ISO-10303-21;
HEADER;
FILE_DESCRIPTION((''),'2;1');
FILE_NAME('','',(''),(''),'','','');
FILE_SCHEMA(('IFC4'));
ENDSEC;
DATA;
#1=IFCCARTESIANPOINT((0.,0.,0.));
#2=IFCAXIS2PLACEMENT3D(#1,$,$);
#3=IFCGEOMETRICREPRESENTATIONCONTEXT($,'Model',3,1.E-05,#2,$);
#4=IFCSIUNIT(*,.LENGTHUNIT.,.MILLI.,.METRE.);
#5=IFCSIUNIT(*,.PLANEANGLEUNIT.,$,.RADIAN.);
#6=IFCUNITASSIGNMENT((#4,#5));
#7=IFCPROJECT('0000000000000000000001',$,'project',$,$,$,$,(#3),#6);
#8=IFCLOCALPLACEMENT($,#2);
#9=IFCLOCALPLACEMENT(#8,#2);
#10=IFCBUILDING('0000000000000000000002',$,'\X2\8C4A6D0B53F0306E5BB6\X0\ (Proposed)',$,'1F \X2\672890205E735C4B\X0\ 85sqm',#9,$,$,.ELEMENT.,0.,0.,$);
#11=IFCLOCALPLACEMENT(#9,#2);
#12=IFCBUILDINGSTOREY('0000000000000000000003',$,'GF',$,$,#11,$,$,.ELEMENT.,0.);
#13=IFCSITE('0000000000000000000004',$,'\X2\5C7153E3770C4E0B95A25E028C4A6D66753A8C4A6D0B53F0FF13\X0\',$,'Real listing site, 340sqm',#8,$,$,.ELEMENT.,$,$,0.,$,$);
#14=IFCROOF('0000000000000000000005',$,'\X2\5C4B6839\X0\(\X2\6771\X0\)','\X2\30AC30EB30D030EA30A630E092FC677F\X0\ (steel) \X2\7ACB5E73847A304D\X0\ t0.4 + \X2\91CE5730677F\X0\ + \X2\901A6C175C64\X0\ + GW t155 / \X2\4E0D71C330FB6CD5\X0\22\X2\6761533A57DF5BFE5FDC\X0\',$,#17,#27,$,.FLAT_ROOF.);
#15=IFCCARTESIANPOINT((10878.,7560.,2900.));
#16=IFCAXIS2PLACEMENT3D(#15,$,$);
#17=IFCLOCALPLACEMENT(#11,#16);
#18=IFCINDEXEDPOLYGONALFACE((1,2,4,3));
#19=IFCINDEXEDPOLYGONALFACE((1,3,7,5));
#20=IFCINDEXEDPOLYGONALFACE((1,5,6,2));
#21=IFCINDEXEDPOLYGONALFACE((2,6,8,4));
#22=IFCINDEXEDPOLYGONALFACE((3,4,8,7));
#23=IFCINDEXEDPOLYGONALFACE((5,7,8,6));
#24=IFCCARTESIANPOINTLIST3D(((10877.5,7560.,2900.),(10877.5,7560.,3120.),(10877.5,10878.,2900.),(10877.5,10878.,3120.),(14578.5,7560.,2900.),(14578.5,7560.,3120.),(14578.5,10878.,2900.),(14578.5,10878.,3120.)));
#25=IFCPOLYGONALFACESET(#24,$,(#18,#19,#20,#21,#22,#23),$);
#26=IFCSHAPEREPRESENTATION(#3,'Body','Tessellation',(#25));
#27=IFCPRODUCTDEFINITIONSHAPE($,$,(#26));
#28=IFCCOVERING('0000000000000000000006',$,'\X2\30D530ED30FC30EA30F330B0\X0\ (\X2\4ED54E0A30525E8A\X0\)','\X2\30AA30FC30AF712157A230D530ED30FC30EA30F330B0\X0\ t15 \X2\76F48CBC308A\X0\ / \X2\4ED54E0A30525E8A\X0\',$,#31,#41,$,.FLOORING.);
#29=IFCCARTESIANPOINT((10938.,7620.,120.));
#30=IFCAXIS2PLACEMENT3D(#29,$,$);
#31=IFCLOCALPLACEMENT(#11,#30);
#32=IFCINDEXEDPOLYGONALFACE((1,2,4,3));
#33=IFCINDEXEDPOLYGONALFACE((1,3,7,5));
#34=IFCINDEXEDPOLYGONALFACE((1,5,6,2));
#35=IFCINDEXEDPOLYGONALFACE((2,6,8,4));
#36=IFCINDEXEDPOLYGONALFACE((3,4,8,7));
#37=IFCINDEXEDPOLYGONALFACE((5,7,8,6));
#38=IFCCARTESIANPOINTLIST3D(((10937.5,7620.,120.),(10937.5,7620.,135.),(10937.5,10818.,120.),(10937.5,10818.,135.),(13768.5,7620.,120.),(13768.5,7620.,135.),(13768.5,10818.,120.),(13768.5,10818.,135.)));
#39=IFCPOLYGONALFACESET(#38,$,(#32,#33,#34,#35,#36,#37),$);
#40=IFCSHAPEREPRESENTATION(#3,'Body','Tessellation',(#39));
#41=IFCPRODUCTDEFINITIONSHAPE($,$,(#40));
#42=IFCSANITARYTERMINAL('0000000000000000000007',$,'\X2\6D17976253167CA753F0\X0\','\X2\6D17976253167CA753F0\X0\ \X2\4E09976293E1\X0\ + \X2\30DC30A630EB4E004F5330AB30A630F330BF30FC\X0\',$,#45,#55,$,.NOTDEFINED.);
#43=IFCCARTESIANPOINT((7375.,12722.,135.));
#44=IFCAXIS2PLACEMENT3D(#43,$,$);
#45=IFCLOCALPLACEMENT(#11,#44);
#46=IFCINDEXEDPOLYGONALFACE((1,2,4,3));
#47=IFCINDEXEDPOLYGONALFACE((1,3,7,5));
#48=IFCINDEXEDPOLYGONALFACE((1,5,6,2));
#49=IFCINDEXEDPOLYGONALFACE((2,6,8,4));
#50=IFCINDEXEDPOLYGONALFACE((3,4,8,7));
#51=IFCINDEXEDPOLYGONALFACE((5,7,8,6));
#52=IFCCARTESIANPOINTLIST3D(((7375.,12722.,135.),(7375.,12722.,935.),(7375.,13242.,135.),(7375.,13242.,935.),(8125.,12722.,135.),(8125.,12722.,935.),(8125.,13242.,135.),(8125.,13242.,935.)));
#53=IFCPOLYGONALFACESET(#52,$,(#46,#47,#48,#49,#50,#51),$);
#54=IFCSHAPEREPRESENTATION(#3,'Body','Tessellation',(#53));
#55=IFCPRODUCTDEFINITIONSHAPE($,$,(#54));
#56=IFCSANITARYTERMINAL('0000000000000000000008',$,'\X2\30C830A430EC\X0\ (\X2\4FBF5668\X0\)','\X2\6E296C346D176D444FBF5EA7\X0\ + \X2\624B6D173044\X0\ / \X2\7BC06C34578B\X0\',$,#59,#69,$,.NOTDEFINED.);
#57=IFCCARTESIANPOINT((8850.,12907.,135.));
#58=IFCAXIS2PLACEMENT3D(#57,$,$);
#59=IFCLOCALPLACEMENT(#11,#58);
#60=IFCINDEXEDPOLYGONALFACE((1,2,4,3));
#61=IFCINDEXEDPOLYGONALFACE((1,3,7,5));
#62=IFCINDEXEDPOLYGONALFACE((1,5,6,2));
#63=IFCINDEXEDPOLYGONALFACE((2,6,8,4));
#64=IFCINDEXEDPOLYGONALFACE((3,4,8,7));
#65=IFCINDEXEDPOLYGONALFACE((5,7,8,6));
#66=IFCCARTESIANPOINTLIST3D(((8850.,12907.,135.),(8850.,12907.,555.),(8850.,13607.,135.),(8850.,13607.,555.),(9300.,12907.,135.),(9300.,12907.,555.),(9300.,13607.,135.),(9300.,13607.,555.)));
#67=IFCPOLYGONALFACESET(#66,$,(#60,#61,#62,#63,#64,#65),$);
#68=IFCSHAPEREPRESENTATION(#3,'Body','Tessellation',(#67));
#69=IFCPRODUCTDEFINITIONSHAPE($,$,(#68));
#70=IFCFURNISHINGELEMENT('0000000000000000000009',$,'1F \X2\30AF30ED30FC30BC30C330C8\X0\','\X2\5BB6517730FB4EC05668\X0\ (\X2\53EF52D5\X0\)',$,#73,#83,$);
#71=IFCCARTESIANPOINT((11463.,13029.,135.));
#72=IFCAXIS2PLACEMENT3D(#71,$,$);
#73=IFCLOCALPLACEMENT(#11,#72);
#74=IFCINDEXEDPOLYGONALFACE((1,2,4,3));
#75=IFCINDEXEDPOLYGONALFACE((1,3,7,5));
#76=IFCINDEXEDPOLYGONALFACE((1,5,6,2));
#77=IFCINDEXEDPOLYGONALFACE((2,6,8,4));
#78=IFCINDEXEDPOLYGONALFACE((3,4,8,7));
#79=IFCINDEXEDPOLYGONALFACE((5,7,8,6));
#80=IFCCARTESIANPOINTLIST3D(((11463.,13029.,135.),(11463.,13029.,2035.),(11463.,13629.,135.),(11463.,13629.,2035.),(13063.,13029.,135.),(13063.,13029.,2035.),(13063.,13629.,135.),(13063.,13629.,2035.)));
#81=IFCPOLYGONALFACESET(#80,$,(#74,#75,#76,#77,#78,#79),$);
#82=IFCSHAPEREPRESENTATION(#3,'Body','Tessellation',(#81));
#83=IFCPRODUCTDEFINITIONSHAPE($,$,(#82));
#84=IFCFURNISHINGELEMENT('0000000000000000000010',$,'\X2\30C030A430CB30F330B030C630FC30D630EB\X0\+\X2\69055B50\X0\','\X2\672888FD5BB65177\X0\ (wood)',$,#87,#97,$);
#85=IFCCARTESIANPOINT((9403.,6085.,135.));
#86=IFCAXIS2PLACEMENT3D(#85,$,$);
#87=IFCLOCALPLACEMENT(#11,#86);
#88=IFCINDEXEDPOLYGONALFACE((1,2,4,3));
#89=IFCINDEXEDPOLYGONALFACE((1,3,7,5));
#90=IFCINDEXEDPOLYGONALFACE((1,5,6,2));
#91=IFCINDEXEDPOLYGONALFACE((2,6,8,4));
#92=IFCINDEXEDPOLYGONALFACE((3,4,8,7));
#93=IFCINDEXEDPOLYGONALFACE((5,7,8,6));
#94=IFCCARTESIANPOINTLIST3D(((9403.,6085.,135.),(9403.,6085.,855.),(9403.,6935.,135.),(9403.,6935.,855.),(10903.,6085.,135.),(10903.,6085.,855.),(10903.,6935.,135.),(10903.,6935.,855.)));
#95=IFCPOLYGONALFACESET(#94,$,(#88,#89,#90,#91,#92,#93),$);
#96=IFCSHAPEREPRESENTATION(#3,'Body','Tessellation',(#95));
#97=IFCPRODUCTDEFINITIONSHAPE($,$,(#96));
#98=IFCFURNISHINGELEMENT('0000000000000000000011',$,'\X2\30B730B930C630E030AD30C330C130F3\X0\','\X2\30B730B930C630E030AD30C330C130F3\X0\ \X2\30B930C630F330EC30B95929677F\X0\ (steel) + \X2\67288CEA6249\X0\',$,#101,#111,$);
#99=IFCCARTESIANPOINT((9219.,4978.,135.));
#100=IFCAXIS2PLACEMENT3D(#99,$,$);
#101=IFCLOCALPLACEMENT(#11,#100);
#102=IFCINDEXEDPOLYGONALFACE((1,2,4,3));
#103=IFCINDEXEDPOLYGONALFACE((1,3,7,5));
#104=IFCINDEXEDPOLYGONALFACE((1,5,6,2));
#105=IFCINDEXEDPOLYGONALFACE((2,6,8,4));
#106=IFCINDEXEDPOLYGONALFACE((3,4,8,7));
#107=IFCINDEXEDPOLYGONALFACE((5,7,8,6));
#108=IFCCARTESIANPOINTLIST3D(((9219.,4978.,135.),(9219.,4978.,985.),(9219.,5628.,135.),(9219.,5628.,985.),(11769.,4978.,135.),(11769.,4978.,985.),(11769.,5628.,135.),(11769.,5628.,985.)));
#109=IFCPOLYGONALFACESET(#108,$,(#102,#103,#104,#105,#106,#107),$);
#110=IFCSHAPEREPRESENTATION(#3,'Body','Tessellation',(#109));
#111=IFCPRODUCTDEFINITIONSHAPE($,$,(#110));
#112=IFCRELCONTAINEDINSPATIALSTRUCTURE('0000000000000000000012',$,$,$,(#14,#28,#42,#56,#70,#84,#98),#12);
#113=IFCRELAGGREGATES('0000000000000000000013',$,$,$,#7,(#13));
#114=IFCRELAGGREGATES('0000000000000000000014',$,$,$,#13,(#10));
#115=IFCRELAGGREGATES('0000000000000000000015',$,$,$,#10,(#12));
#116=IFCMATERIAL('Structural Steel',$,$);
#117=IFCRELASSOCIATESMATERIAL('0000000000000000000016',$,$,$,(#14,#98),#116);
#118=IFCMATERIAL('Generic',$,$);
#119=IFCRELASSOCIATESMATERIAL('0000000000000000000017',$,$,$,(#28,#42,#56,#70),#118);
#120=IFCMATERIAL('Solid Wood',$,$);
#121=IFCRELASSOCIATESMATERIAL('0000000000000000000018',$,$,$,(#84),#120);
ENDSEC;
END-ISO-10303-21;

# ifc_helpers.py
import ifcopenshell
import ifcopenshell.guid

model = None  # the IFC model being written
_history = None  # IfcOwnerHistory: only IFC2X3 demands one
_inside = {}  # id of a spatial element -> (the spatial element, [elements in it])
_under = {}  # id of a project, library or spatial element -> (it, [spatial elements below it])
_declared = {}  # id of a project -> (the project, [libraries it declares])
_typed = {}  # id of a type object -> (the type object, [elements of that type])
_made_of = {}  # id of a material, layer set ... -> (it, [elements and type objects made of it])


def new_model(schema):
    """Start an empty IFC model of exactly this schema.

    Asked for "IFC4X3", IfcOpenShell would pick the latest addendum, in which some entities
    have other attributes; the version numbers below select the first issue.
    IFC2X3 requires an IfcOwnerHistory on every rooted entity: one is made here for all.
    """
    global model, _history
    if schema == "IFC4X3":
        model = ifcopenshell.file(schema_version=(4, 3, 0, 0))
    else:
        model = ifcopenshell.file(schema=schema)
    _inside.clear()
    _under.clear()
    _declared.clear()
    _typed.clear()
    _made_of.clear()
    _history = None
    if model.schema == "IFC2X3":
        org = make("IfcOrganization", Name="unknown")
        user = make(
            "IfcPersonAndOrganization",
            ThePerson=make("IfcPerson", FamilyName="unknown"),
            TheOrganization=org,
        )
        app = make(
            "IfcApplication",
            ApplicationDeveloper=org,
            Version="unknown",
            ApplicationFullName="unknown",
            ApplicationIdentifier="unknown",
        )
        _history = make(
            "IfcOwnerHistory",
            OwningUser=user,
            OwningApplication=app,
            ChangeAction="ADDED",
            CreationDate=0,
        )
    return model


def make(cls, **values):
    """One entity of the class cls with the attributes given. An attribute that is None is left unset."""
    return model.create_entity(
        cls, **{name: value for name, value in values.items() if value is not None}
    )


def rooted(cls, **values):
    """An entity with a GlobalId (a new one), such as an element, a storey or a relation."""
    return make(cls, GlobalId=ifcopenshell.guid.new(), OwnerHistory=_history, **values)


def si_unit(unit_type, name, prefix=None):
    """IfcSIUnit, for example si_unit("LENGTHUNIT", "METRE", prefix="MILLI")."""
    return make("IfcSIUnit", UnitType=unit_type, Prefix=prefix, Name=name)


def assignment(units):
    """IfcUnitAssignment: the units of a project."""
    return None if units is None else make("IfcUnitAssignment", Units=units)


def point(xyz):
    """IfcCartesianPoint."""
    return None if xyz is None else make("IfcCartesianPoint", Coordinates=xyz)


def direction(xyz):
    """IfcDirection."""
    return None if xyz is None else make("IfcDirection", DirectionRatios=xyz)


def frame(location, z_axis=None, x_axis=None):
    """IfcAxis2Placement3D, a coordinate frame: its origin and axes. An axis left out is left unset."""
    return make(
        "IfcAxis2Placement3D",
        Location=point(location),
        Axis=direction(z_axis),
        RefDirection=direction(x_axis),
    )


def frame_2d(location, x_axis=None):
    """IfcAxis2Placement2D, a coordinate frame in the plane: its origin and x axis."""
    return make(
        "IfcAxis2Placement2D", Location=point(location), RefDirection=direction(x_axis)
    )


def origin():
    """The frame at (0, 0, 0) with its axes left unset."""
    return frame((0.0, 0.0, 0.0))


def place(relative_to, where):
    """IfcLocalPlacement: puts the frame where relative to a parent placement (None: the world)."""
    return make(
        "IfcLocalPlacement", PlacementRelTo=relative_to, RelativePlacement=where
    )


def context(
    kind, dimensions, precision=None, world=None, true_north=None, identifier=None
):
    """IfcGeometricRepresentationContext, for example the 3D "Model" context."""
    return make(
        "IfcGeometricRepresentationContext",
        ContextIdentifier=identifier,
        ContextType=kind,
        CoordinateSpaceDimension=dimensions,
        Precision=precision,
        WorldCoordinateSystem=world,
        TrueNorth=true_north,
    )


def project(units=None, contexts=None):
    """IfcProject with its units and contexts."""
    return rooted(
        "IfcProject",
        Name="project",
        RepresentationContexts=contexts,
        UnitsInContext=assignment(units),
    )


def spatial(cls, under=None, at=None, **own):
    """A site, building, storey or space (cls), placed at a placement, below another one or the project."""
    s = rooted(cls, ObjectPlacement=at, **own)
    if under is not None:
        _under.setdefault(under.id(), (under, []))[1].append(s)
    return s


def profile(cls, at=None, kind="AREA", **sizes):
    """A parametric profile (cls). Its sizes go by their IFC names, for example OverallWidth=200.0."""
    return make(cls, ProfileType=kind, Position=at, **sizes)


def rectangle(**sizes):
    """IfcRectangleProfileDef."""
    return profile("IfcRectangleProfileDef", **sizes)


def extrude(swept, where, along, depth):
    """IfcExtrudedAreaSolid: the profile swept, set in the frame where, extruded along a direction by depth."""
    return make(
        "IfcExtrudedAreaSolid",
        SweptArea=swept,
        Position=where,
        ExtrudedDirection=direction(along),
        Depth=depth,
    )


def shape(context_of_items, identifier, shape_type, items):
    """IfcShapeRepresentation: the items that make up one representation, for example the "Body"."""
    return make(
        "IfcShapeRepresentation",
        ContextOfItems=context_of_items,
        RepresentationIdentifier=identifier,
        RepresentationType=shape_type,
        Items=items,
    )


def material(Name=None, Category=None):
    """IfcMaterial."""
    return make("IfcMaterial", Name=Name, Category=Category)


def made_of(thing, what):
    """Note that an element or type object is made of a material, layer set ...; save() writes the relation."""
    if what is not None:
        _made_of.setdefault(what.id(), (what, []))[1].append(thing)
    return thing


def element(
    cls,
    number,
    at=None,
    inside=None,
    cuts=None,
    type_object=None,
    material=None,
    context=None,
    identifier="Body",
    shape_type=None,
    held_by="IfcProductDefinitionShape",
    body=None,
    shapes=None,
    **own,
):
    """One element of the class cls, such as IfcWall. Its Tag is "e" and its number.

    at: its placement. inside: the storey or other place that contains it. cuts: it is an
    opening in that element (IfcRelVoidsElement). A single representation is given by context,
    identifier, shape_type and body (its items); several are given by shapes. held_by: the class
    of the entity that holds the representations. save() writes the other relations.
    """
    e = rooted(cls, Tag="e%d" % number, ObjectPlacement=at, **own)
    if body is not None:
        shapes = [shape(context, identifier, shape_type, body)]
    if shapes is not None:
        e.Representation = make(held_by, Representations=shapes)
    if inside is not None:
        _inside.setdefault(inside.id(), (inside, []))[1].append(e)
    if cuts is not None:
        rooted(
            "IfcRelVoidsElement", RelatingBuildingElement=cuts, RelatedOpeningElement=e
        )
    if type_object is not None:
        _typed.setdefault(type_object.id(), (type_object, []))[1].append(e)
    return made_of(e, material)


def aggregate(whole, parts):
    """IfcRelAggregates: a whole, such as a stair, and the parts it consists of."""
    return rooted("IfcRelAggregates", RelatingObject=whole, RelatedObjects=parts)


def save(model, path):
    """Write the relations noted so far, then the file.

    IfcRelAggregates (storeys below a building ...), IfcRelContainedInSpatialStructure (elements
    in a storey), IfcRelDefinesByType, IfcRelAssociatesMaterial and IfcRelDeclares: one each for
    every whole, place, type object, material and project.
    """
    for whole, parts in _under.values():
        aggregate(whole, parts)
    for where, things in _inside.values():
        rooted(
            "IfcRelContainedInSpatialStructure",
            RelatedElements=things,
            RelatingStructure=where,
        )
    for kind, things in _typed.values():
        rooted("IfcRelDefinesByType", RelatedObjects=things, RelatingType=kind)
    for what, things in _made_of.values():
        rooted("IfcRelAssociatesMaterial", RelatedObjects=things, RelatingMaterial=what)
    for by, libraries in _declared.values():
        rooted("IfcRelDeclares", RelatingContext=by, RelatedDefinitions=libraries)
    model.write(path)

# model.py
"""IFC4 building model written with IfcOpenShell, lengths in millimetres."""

from ifc_helpers import new_model, si_unit, frame, frame_2d, origin, place, context, project, spatial, rectangle, extrude, material, element, save


model = new_model("IFC4")

# Units and contexts
model_context = context("Model", 3, precision=1e-05, world=origin())
ifc_project = project(units=[si_unit("LENGTHUNIT", "METRE", prefix="MILLI"), si_unit("PLANEANGLEUNIT", "RADIAN")], contexts=[model_context])

# Site, building, storey
site_placement = place(None, origin())
site = spatial("IfcSite", under=ifc_project, at=site_placement, Name="山口県下関市豊浦町豊洋台３", ObjectType="Real listing site, 340sqm", CompositionType="ELEMENT", RefElevation=0.0)
building_placement = place(site_placement, origin())
building = spatial("IfcBuilding", under=site, at=building_placement, Name="豊洋台の家 (Proposed)", ObjectType="1F 木造平屋 85sqm", CompositionType="ELEMENT", ElevationOfRefHeight=0.0, ElevationOfTerrain=0.0)
storey_placement = place(building_placement, origin())
storey = spatial("IfcBuildingStorey", under=building, at=storey_placement, Name="GF", CompositionType="ELEMENT", Elevation=0.0)

# Shared definitions
ifc_material_1 = material(Name="Solid Wood")

# Roof
ifc_material_2 = material(Name="Structural Steel")
roof_placement = place(storey_placement, frame((10878.0, 7560.0, 2900.0)))
element("IfcRoof", 1, at=roof_placement, inside=storey, material=ifc_material_2, Name="屋根(東)", Description="ガルバリウム鋼板 (steel) 立平葺き t0.4 + 野地板 + 通気層 + GW t155 / 不燃・法22条区域対応", PredefinedType="FLAT_ROOF", context=model_context, shape_type="SweptSolid", body=[
    extrude(rectangle(XDim=3701.0, YDim=3318.0, at=frame_2d((1850.0, 1659.0))), frame((10878.0, 7560.0, 2900.0)), (0.0, 0.0, 1.0), 220.0),
])

# Covering
ifc_material_3 = material(Name="Generic")
covering_placement = place(storey_placement, frame((10938.0, 7620.0, 120.0)))
element("IfcCovering", 2, at=covering_placement, inside=storey, material=ifc_material_3, Name="フローリング (仕上げ床)", Description="オーク無垢フローリング t15 直貼り / 仕上げ床", PredefinedType="FLOORING", context=model_context, shape_type="SweptSolid", body=[
    extrude(rectangle(XDim=2831.0, YDim=3198.0, at=frame_2d((1415.0, 1599.0))), frame((10938.0, 7620.0, 120.0)), (0.0, 0.0, 1.0), 15.0),
])

# Sanitary terminals
sanitary_terminal_1_placement = place(storey_placement, frame((7375.0, 12722.0, 135.0)))
element("IfcSanitaryTerminal", 3, at=sanitary_terminal_1_placement, inside=storey, material=ifc_material_3, Name="洗面化粧台", Description="洗面化粧台 三面鏡 + ボウル一体カウンター", PredefinedType="NOTDEFINED", context=model_context, shape_type="SweptSolid", body=[
    extrude(rectangle(XDim=750.0, YDim=520.0, at=frame_2d((375.0, 260.0))), frame((7375.0, 12722.0, 135.0)), (0.0, 0.0, 1.0), 800.0),
])
sanitary_terminal_2_placement = place(storey_placement, frame((8850.0, 12907.0, 135.0)))
element("IfcSanitaryTerminal", 4, at=sanitary_terminal_2_placement, inside=storey, material=ifc_material_3, Name="トイレ (便器)", Description="温水洗浄便座 + 手洗い / 節水型", PredefinedType="NOTDEFINED", context=model_context, shape_type="SweptSolid", body=[
    extrude(rectangle(XDim=450.0, YDim=700.0, at=frame_2d((225.0, 350.0))), frame((8850.0, 12907.0, 135.0)), (0.0, 0.0, 1.0), 420.0),
])

# Furnishing elements
furnishing_1_placement = place(storey_placement, frame((11463.0, 13029.0, 135.0)))
element("IfcFurnishingElement", 5, at=furnishing_1_placement, inside=storey, material=ifc_material_3, Name="1F クローゼット", Description="家具・什器 (可動)", context=model_context, shape_type="SweptSolid", body=[
    extrude(rectangle(XDim=1600.0, YDim=600.0, at=frame_2d((800.0, 300.0))), frame((11463.0, 13029.0, 135.0)), (0.0, 0.0, 1.0), 1900.0),
])
furnishing_2_placement = place(storey_placement, frame((9403.0, 6085.0, 135.0)))
element("IfcFurnishingElement", 6, at=furnishing_2_placement, inside=storey, material=ifc_material_1, Name="ダイニングテーブル+椅子", Description="木製家具 (wood)", context=model_context, shape_type="SweptSolid", body=[
    extrude(rectangle(XDim=1500.0, YDim=850.0, at=frame_2d((750.0, 425.0))), frame((9403.0, 6085.0, 135.0)), (0.0, 0.0, 1.0), 720.0),
])
furnishing_3_placement = place(storey_placement, frame((9219.0, 4978.0, 135.0)))
element("IfcFurnishingElement", 7, at=furnishing_3_placement, inside=storey, material=ifc_material_2, Name="システムキッチン", Description="システムキッチン ステンレス天板 (steel) + 木質扉", context=model_context, shape_type="SweptSolid", body=[
    extrude(rectangle(XDim=2550.0, YDim=650.0, at=frame_2d((1275.0, 325.0))), frame((9219.0, 4978.0, 135.0)), (0.0, 0.0, 1.0), 850.0),
])

save(model, "model.ifc")
